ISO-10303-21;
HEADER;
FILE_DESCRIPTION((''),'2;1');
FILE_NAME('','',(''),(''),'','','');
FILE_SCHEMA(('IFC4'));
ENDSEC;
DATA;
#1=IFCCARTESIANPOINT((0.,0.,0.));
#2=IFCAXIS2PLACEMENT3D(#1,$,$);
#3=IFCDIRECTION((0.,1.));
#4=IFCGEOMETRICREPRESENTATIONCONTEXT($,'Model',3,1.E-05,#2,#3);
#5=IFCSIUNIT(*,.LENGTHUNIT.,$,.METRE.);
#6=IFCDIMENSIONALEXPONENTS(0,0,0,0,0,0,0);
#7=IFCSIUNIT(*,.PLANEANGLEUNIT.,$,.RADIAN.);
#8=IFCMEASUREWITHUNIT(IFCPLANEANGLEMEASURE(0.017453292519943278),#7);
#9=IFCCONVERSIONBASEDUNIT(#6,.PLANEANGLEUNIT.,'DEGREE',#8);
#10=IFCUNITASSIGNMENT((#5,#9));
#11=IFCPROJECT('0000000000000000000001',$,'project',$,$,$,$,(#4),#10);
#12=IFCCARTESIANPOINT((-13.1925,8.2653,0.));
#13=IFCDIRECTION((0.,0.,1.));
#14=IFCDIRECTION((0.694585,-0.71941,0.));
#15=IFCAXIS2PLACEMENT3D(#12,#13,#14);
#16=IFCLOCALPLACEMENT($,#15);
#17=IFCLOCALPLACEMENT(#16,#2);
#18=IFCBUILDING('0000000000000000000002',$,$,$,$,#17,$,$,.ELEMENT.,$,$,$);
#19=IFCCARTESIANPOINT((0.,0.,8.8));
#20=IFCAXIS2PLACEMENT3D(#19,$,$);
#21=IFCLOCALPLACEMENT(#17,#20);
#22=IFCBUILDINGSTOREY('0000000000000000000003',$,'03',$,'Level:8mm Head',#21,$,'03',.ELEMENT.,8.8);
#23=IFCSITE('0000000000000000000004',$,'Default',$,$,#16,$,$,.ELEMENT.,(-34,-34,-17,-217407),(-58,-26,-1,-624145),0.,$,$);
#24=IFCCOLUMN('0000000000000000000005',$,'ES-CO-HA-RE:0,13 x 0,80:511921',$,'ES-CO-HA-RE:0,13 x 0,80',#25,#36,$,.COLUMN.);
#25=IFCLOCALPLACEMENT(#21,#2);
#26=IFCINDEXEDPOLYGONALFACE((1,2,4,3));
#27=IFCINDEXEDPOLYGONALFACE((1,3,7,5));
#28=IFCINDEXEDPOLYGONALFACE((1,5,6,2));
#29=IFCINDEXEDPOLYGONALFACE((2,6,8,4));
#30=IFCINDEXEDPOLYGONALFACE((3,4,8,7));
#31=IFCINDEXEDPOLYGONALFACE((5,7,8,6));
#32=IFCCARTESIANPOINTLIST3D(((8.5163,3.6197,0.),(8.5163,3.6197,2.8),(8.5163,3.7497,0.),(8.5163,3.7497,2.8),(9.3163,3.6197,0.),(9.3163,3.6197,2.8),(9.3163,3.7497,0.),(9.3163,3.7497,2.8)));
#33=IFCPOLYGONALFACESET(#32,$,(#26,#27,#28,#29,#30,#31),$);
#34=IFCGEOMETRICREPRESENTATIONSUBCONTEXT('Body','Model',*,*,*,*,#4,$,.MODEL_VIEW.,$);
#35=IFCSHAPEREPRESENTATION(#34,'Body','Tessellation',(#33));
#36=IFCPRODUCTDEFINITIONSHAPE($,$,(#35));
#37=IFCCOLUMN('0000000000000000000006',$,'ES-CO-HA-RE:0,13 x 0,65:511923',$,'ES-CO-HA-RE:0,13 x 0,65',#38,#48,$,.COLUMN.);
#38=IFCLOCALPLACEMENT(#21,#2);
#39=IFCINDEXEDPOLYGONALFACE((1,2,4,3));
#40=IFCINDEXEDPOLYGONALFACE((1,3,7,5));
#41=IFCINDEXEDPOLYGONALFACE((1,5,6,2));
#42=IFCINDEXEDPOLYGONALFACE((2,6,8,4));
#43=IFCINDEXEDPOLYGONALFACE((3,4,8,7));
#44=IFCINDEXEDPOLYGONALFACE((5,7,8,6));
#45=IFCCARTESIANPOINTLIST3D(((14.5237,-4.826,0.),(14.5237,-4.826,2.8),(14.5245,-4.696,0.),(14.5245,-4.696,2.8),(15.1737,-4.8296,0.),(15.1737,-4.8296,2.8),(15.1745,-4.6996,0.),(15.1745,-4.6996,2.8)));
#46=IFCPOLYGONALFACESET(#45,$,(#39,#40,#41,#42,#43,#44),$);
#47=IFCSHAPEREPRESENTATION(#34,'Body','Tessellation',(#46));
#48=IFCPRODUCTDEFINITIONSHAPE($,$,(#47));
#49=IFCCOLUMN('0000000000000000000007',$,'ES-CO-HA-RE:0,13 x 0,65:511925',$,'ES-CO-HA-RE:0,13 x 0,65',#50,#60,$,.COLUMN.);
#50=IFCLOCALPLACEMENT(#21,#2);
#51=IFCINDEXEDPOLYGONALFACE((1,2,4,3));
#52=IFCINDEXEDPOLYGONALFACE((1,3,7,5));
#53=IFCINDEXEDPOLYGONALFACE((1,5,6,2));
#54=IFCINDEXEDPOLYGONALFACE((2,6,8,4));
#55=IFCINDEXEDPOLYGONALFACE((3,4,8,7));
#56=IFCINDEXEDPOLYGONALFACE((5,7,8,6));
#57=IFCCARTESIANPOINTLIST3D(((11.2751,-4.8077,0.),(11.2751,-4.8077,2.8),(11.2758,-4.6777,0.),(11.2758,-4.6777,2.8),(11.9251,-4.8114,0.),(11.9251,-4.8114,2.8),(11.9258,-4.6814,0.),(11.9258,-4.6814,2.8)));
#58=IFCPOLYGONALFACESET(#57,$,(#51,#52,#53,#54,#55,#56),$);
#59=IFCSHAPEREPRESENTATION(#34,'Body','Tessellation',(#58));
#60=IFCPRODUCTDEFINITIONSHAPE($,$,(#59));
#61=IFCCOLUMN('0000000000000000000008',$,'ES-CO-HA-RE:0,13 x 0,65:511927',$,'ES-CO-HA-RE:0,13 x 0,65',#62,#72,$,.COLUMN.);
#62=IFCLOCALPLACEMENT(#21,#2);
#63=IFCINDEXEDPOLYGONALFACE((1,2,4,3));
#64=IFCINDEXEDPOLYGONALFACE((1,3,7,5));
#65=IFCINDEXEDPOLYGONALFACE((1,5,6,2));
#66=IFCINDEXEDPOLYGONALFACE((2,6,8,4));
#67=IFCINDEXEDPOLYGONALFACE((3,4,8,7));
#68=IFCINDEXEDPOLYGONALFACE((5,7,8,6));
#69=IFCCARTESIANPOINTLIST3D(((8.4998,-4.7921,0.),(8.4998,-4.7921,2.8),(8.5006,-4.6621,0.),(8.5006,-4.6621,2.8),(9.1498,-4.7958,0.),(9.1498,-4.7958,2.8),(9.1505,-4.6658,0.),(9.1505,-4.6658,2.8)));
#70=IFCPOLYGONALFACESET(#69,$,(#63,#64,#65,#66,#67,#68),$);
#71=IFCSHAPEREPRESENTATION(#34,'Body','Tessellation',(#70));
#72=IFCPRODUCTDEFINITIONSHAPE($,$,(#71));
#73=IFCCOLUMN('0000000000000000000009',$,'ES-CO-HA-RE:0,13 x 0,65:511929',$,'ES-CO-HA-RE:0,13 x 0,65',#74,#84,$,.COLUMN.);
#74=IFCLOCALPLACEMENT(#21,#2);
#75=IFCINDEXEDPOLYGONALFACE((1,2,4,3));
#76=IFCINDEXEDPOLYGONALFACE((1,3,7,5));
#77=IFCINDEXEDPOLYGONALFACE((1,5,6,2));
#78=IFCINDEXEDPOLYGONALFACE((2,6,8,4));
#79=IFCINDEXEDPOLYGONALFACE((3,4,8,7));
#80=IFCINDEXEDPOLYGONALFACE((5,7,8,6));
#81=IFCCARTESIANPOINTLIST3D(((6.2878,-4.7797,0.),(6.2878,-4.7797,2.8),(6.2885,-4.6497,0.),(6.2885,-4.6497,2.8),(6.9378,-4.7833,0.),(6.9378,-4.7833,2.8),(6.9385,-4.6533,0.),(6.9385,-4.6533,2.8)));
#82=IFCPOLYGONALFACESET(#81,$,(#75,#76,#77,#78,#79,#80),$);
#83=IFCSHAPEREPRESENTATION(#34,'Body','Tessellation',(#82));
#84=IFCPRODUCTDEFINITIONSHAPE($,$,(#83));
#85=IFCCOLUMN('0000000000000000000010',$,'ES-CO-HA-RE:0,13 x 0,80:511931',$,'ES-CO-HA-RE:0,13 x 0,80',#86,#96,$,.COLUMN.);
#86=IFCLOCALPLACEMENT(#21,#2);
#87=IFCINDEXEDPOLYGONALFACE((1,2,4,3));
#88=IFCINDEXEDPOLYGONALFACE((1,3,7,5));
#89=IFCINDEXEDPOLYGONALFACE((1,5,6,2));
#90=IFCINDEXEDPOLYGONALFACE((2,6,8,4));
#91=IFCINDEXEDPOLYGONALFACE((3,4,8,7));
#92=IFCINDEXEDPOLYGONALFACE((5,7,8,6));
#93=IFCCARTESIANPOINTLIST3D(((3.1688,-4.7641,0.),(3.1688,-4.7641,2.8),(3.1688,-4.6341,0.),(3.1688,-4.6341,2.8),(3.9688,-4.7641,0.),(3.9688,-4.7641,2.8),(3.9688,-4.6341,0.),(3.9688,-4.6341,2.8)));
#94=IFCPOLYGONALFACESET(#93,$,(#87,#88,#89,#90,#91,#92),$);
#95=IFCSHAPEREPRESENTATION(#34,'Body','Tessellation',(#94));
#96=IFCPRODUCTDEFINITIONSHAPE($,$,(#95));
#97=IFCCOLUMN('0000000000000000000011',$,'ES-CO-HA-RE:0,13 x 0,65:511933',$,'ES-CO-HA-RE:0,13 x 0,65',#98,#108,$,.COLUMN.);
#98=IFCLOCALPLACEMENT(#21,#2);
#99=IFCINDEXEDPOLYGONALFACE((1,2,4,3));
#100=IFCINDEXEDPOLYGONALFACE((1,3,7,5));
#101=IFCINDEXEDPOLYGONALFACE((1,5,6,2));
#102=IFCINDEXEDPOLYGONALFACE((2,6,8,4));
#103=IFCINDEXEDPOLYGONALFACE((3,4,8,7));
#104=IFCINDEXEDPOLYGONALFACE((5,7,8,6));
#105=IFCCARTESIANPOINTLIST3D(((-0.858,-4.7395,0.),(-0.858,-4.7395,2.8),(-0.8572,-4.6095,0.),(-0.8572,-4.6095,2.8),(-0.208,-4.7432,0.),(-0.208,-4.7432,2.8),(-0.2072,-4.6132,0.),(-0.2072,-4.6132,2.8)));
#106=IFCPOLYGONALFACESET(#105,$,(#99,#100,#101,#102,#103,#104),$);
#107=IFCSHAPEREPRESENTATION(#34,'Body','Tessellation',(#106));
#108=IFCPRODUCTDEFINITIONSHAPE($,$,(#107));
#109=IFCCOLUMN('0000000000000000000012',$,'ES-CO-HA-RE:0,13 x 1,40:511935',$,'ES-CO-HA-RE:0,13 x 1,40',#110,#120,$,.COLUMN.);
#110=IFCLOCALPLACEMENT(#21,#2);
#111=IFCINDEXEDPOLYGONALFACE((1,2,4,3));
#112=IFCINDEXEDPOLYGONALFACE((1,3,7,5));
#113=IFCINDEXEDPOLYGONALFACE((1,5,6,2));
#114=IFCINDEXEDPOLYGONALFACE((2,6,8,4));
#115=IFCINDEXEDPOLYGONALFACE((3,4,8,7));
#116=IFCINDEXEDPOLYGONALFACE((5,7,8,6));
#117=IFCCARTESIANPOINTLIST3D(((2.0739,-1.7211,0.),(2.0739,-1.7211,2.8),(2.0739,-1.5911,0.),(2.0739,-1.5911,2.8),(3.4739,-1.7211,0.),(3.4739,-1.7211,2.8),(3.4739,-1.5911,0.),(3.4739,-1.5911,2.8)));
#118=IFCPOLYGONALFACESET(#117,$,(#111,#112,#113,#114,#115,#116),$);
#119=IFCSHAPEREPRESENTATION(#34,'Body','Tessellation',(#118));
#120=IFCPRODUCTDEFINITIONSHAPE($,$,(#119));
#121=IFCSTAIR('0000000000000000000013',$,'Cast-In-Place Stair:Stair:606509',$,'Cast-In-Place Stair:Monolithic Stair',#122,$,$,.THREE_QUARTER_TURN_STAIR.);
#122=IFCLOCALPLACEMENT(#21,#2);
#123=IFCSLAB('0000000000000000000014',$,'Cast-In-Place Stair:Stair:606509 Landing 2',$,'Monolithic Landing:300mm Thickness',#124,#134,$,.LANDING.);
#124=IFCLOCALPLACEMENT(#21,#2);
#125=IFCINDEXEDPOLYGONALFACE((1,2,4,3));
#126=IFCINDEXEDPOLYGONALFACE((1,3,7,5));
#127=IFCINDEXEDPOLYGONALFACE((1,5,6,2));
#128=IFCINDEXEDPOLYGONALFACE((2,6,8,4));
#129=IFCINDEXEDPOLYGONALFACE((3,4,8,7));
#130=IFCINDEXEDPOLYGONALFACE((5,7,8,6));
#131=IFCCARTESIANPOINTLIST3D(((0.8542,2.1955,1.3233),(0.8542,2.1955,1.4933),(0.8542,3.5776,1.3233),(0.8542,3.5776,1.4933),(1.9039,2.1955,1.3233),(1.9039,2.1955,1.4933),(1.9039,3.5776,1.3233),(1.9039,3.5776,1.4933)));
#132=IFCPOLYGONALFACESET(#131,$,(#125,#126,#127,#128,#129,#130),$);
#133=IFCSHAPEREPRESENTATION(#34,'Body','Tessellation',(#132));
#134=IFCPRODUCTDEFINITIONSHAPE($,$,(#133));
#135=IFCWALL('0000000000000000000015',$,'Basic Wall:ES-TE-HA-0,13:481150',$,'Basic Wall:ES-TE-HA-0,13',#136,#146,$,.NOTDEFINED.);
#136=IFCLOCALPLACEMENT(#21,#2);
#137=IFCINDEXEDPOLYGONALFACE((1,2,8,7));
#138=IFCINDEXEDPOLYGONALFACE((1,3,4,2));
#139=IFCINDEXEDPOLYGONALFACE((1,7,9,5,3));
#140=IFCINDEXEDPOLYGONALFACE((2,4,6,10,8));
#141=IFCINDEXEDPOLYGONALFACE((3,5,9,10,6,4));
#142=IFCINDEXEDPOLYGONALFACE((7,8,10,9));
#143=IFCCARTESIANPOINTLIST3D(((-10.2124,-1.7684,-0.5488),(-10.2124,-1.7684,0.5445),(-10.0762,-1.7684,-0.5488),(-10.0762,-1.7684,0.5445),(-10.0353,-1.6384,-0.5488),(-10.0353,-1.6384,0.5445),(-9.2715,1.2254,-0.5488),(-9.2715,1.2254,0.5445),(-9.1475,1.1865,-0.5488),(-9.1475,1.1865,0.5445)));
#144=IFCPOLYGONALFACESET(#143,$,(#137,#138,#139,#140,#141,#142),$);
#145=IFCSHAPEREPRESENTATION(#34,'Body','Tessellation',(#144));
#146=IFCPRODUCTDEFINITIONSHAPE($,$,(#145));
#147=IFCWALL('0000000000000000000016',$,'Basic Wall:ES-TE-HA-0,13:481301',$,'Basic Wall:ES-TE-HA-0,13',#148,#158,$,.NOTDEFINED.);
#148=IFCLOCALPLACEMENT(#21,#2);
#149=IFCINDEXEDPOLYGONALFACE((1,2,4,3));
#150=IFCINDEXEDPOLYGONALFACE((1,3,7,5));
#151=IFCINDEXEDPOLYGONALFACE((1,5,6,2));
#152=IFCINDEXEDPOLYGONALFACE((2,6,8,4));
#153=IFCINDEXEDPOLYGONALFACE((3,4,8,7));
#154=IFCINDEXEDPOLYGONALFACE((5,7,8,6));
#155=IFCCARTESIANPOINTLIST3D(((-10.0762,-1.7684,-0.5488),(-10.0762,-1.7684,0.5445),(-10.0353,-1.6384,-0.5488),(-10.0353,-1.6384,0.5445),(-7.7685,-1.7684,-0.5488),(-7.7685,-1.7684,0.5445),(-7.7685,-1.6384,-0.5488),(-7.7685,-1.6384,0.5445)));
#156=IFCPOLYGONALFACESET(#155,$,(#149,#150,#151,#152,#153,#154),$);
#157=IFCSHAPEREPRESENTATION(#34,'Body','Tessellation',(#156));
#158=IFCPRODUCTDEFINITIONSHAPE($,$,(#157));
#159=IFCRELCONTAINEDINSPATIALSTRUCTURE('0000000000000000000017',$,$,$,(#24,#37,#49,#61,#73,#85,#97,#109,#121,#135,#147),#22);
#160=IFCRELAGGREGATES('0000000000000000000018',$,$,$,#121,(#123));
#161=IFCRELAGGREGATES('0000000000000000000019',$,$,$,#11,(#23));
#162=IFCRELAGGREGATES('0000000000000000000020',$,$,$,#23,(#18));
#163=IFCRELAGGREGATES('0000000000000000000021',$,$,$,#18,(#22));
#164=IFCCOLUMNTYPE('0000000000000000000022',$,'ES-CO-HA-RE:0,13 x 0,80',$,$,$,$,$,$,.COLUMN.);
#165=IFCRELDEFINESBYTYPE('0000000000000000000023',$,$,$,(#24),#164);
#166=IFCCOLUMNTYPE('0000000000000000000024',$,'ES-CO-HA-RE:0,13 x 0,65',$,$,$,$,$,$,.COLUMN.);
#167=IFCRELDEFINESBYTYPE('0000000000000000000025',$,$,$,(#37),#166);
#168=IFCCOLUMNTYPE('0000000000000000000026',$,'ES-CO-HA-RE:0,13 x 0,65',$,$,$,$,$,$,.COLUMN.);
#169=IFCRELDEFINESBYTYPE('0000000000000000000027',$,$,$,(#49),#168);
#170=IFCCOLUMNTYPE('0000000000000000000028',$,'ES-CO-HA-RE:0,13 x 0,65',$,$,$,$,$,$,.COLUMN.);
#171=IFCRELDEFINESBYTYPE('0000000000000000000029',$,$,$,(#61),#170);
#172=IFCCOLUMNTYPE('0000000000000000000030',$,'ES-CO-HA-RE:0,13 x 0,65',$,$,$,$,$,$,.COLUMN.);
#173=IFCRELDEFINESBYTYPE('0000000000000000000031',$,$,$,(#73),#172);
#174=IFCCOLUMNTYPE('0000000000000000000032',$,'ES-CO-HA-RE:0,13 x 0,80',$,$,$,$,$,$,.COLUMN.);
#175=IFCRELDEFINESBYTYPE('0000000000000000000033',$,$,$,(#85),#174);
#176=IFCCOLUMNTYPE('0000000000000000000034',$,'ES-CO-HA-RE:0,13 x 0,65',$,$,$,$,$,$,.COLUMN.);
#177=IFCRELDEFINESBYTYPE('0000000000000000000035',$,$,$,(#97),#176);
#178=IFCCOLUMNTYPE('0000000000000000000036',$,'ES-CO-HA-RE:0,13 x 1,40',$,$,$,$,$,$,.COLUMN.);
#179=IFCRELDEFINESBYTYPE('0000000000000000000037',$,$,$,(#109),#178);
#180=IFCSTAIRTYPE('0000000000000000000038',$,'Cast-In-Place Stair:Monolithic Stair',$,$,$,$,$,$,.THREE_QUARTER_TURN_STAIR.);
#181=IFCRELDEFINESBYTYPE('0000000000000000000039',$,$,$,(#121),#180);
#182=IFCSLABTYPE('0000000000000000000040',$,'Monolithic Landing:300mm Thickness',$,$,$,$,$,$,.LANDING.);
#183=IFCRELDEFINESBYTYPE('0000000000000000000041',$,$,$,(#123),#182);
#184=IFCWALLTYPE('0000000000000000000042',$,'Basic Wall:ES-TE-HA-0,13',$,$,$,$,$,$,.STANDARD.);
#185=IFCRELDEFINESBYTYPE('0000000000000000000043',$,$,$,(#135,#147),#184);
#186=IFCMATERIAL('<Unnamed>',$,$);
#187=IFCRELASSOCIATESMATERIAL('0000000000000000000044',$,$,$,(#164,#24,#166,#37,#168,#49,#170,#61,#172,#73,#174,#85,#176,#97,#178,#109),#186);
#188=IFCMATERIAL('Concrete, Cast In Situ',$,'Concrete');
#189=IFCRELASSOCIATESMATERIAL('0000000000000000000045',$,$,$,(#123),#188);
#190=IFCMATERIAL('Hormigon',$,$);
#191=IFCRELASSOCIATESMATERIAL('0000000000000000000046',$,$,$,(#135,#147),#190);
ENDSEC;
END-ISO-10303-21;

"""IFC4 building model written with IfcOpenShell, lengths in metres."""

from ifc_helpers import new_model, entity, si_unit, converted_unit, direction, frame, origin, place, context, subcontext, project, spatial, indexed_curve, outline, extrude, source, transform, mapped, material, type_object, type_shapes, element, aggregate, save


model = new_model("IFC4")

# Units and contexts
model_context = context("Model", 3, precision=1e-05, world=origin(), true_north=direction((0.0, 1.0)))
body_context = subcontext(model_context, "Body", "Model", "MODEL_VIEW")
ifc_project = project(units=[si_unit("LENGTHUNIT", "METRE"), converted_unit("PLANEANGLEUNIT", "DEGREE", entity("IfcPlaneAngleMeasure", 0.017453292519943278), si_unit("PLANEANGLEUNIT", "RADIAN"), dimensions=[0, 0, 0, 0, 0, 0, 0])], contexts=[model_context])

# Site, building, storey
site_placement = place(None, frame((-13.1925, 8.2653, 0.0), z_axis=(0.0, 0.0, 1.0), x_axis=(0.694585, -0.71941, 0.0)))
site = spatial("IfcSite", under=ifc_project, at=site_placement, Name="Default", CompositionType="ELEMENT", RefLatitude=(-34, -34, -17, -217407), RefLongitude=(-58, -26, -1, -624145), RefElevation=0.0)
building_placement = place(site_placement, origin())
building = spatial("IfcBuilding", under=site, at=building_placement, CompositionType="ELEMENT")
storey_placement = place(building_placement, frame((0.0, 0.0, 8.8)))
storey = spatial("IfcBuildingStorey", under=building, at=storey_placement, Name="03", ObjectType="Level:8mm Head", LongName="03", CompositionType="ELEMENT", Elevation=8.8)

# Columns
ifc_material_1 = material(Name="<Unnamed>")
ifc_material_2 = material(Name="Hormigon")
column_type_1 = type_object("IfcColumnType", Name="ES-CO-HA-RE:0,13 x 0,80", PredefinedType="COLUMN", material=ifc_material_1)
shared_shape_1 = source(origin(), body_context, "Body", "SweptSolid", [
    extrude(outline(indexed_curve([(-0.4, -0.065), (0.4, -0.065), (0.4, 0.065), (-0.4, 0.065), (-0.4, -0.065)], self_intersect=False)), frame((8.9163, 3.6847, 8.8), z_axis=(0.0, 0.0, 1.0), x_axis=(-1.0, 0.0, 0.0)), (0.0, 0.0, 1.0), 2.8),
])
type_shapes(column_type_1, [shared_shape_1])
column_1_placement = place(storey_placement, frame((0.0, 0.0, -8.8)))
element("IfcColumn", 1, at=column_1_placement, inside=storey, type_object=column_type_1, material=ifc_material_1, Name="ES-CO-HA-RE:0,13 x 0,80:511921", ObjectType="ES-CO-HA-RE:0,13 x 0,80", PredefinedType="COLUMN", context=body_context, shape_type="MappedRepresentation", body=[
    mapped(shared_shape_1, transform((0.0, 0.0, 0.0), scale=1.0)),
])
column_type_2 = type_object("IfcColumnType", Name="ES-CO-HA-RE:0,13 x 0,65", PredefinedType="COLUMN", material=ifc_material_1)
shared_shape_2 = source(origin(), body_context, "Body", "SweptSolid", [
    extrude(outline(indexed_curve([(-0.325, -0.065), (0.325, -0.065), (0.325, 0.065), (-0.325, 0.065), (-0.325, -0.065)], self_intersect=False)), frame((14.8491, -4.7628, 8.8), z_axis=(0.0, 0.0, 1.0), x_axis=(-0.999984, 0.005619, 0.0)), (0.0, 0.0, 1.0), 2.8),
])
type_shapes(column_type_2, [shared_shape_2])
column_2_placement = place(storey_placement, frame((0.0, 0.0, -8.8)))
element("IfcColumn", 2, at=column_2_placement, inside=storey, type_object=column_type_2, material=ifc_material_1, Name="ES-CO-HA-RE:0,13 x 0,65:511923", ObjectType="ES-CO-HA-RE:0,13 x 0,65", PredefinedType="COLUMN", context=body_context, shape_type="MappedRepresentation", body=[
    mapped(shared_shape_2, transform((0.0, 0.0, 0.0), scale=1.0)),
])
column_type_3 = type_object("IfcColumnType", Name="ES-CO-HA-RE:0,13 x 0,65", PredefinedType="COLUMN", material=ifc_material_1)
shared_shape_3 = source(origin(), body_context, "Body", "SweptSolid", [
    extrude(outline(indexed_curve([(-0.325, -0.065), (0.325, -0.065), (0.325, 0.065), (-0.325, 0.065), (-0.325, -0.065)], self_intersect=False)), frame((11.6005, -4.7445, 8.8), z_axis=(0.0, 0.0, 1.0), x_axis=(-0.999984, 0.005619, 0.0)), (0.0, 0.0, 1.0), 2.8),
])
type_shapes(column_type_3, [shared_shape_3])
column_3_placement = place(storey_placement, frame((0.0, 0.0, -8.8)))
element("IfcColumn", 3, at=column_3_placement, inside=storey, type_object=column_type_3, material=ifc_material_1, Name="ES-CO-HA-RE:0,13 x 0,65:511925", ObjectType="ES-CO-HA-RE:0,13 x 0,65", PredefinedType="COLUMN", context=body_context, shape_type="MappedRepresentation", body=[
    mapped(shared_shape_3, transform((0.0, 0.0, 0.0), scale=1.0)),
])
column_type_4 = type_object("IfcColumnType", Name="ES-CO-HA-RE:0,13 x 0,65", PredefinedType="COLUMN", material=ifc_material_1)
shared_shape_4 = source(origin(), body_context, "Body", "SweptSolid", [
    extrude(outline(indexed_curve([(-0.325, -0.065), (0.325, -0.065), (0.325, 0.065), (-0.325, 0.065), (-0.325, -0.065)], self_intersect=False)), frame((8.8252, -4.7289, 8.8), z_axis=(0.0, 0.0, 1.0), x_axis=(-0.999984, 0.005619, 0.0)), (0.0, 0.0, 1.0), 2.8),
])
type_shapes(column_type_4, [shared_shape_4])
column_4_placement = place(storey_placement, frame((0.0, 0.0, -8.8)))
element("IfcColumn", 4, at=column_4_placement, inside=storey, type_object=column_type_4, material=ifc_material_1, Name="ES-CO-HA-RE:0,13 x 0,65:511927", ObjectType="ES-CO-HA-RE:0,13 x 0,65", PredefinedType="COLUMN", context=body_context, shape_type="MappedRepresentation", body=[
    mapped(shared_shape_4, transform((0.0, 0.0, 0.0), scale=1.0)),
])
column_type_5 = type_object("IfcColumnType", Name="ES-CO-HA-RE:0,13 x 0,65", PredefinedType="COLUMN", material=ifc_material_1)
shared_shape_5 = source(origin(), body_context, "Body", "SweptSolid", [
    extrude(outline(indexed_curve([(-0.325, -0.065), (0.325, -0.065), (0.325, 0.065), (-0.325, 0.065), (-0.325, -0.065)], self_intersect=False)), frame((6.6131, -4.7165, 8.8), z_axis=(0.0, 0.0, 1.0), x_axis=(-0.999984, 0.005619, 0.0)), (0.0, 0.0, 1.0), 2.8),
])
type_shapes(column_type_5, [shared_shape_5])
column_5_placement = place(storey_placement, frame((0.0, 0.0, -8.8)))
element("IfcColumn", 5, at=column_5_placement, inside=storey, type_object=column_type_5, material=ifc_material_1, Name="ES-CO-HA-RE:0,13 x 0,65:511929", ObjectType="ES-CO-HA-RE:0,13 x 0,65", PredefinedType="COLUMN", context=body_context, shape_type="MappedRepresentation", body=[
    mapped(shared_shape_5, transform((0.0, 0.0, 0.0), scale=1.0)),
])
column_type_6 = type_object("IfcColumnType", Name="ES-CO-HA-RE:0,13 x 0,80", PredefinedType="COLUMN", material=ifc_material_1)
shared_shape_6 = source(origin(), body_context, "Body", "SweptSolid", [
    extrude(outline(indexed_curve([(-0.4, -0.065), (0.4, -0.065), (0.4, 0.065), (-0.4, 0.065), (-0.4, -0.065)], self_intersect=False)), frame((3.5688, -4.6991, 8.8), z_axis=(0.0, 0.0, 1.0), x_axis=(-1.0, 0.0, 0.0)), (0.0, 0.0, 1.0), 2.8),
])
type_shapes(column_type_6, [shared_shape_6])
column_6_placement = place(storey_placement, frame((0.0, 0.0, -8.8)))
element("IfcColumn", 6, at=column_6_placement, inside=storey, type_object=column_type_6, material=ifc_material_1, Name="ES-CO-HA-RE:0,13 x 0,80:511931", ObjectType="ES-CO-HA-RE:0,13 x 0,80", PredefinedType="COLUMN", context=body_context, shape_type="MappedRepresentation", body=[
    mapped(shared_shape_6, transform((0.0, 0.0, 0.0), scale=1.0)),
])
column_type_7 = type_object("IfcColumnType", Name="ES-CO-HA-RE:0,13 x 0,65", PredefinedType="COLUMN", material=ifc_material_1)
shared_shape_7 = source(origin(), body_context, "Body", "SweptSolid", [
    extrude(outline(indexed_curve([(-0.325, -0.065), (0.325, -0.065), (0.325, 0.065), (-0.325, 0.065), (-0.325, -0.065)], self_intersect=False)), frame((-0.5326, -4.6764, 8.8), z_axis=(0.0, 0.0, 1.0), x_axis=(-0.999984, 0.005619, 0.0)), (0.0, 0.0, 1.0), 2.8),
])
type_shapes(column_type_7, [shared_shape_7])
column_7_placement = place(storey_placement, frame((0.0, 0.0, -8.8)))
element("IfcColumn", 7, at=column_7_placement, inside=storey, type_object=column_type_7, material=ifc_material_1, Name="ES-CO-HA-RE:0,13 x 0,65:511933", ObjectType="ES-CO-HA-RE:0,13 x 0,65", PredefinedType="COLUMN", context=body_context, shape_type="MappedRepresentation", body=[
    mapped(shared_shape_7, transform((0.0, 0.0, 0.0), scale=1.0)),
])
column_type_8 = type_object("IfcColumnType", Name="ES-CO-HA-RE:0,13 x 1,40", PredefinedType="COLUMN", material=ifc_material_1)
shared_shape_8 = source(origin(), body_context, "Body", "SweptSolid", [
    extrude(outline(indexed_curve([(-0.7, -0.065), (0.7, -0.065), (0.7, 0.065), (-0.7, 0.065), (-0.7, -0.065)], self_intersect=False)), frame((2.7739, -1.6561, 8.8), z_axis=(0.0, 0.0, 1.0), x_axis=(-1.0, 0.0, 0.0)), (0.0, 0.0, 1.0), 2.8),
])
type_shapes(column_type_8, [shared_shape_8])
column_8_placement = place(storey_placement, frame((0.0, 0.0, -8.8)))
element("IfcColumn", 8, at=column_8_placement, inside=storey, type_object=column_type_8, material=ifc_material_1, Name="ES-CO-HA-RE:0,13 x 1,40:511935", ObjectType="ES-CO-HA-RE:0,13 x 1,40", PredefinedType="COLUMN", context=body_context, shape_type="MappedRepresentation", body=[
    mapped(shared_shape_8, transform((0.0, 0.0, 0.0), scale=1.0)),
])

# Stair, slab
stair_type = type_object("IfcStairType", Name="Cast-In-Place Stair:Monolithic Stair", PredefinedType="THREE_QUARTER_TURN_STAIR")
stair_placement = place(storey_placement, origin())
stair = element("IfcStair", 9, at=stair_placement, inside=storey, type_object=stair_type, Name="Cast-In-Place Stair:Stair:606509", ObjectType="Cast-In-Place Stair:Monolithic Stair", PredefinedType="THREE_QUARTER_TURN_STAIR")
ifc_material_3 = material(Name="Concrete, Cast In Situ", Category="Concrete")
slab_type = type_object("IfcSlabType", Name="Monolithic Landing:300mm Thickness", PredefinedType="LANDING")
slab_1_placement = place(stair_placement, origin())
slab_1 = element("IfcSlab", 10, at=slab_1_placement, type_object=slab_type, material=ifc_material_3, Name="Cast-In-Place Stair:Stair:606509 Landing 2", ObjectType="Monolithic Landing:300mm Thickness", PredefinedType="LANDING", context=body_context, shape_type="SweptSolid", body=[
    extrude(outline(indexed_curve([(-0.6911, -0.5249), (0.6911, -0.5249), (0.6911, 0.5249), (-0.6911, 0.5249), (-0.6911, -0.5249)], self_intersect=False)), frame((1.379, 2.8866, 1.3233), z_axis=(0.0, 0.0, 1.0), x_axis=(0.0, 1.0, 0.0)), (0.0, 0.0, 1.0), 0.17),
])

# Walls
wall_type = type_object("IfcWallType", Name="Basic Wall:ES-TE-HA-0,13", PredefinedType="STANDARD")
wall_1_placement = place(storey_placement, frame((-10.1504, -1.7879, -0.5488), z_axis=(0.0, 0.0, 1.0), x_axis=(0.299835, 0.953991, 0.0)))
element("IfcWall", 11, at=wall_1_placement, inside=storey, type_object=wall_type, material=ifc_material_2, Name="Basic Wall:ES-TE-HA-0,13:481150", ObjectType="Basic Wall:ES-TE-HA-0,13", PredefinedType="NOTDEFINED", context=body_context, shape_type="SweptSolid", body=[
    extrude(outline(indexed_curve([(3.1382, -0.065), (3.1382, 0.065), (0.0, 0.065), (0.0409, -0.065), (0.1771, -0.065), (3.1382, -0.065)], self_intersect=False)), origin(), (0.0, 0.0, 1.0), 1.0933),
])
wall_2_placement = place(storey_placement, frame((-10.0762, -1.7034, -0.5488)))
element("IfcWall", 12, at=wall_2_placement, inside=storey, type_object=wall_type, material=ifc_material_2, Name="Basic Wall:ES-TE-HA-0,13:481301", ObjectType="Basic Wall:ES-TE-HA-0,13", PredefinedType="NOTDEFINED", context=body_context, shape_type="SweptSolid", body=[
    extrude(outline(indexed_curve([(2.3077, -0.065), (2.3077, 0.065), (0.0409, 0.065), (0.0, -0.065), (2.3077, -0.065)], self_intersect=False)), origin(), (0.0, 0.0, 1.0), 1.0933),
])

aggregate(stair, [slab_1])

save(model, "model.ifc")
